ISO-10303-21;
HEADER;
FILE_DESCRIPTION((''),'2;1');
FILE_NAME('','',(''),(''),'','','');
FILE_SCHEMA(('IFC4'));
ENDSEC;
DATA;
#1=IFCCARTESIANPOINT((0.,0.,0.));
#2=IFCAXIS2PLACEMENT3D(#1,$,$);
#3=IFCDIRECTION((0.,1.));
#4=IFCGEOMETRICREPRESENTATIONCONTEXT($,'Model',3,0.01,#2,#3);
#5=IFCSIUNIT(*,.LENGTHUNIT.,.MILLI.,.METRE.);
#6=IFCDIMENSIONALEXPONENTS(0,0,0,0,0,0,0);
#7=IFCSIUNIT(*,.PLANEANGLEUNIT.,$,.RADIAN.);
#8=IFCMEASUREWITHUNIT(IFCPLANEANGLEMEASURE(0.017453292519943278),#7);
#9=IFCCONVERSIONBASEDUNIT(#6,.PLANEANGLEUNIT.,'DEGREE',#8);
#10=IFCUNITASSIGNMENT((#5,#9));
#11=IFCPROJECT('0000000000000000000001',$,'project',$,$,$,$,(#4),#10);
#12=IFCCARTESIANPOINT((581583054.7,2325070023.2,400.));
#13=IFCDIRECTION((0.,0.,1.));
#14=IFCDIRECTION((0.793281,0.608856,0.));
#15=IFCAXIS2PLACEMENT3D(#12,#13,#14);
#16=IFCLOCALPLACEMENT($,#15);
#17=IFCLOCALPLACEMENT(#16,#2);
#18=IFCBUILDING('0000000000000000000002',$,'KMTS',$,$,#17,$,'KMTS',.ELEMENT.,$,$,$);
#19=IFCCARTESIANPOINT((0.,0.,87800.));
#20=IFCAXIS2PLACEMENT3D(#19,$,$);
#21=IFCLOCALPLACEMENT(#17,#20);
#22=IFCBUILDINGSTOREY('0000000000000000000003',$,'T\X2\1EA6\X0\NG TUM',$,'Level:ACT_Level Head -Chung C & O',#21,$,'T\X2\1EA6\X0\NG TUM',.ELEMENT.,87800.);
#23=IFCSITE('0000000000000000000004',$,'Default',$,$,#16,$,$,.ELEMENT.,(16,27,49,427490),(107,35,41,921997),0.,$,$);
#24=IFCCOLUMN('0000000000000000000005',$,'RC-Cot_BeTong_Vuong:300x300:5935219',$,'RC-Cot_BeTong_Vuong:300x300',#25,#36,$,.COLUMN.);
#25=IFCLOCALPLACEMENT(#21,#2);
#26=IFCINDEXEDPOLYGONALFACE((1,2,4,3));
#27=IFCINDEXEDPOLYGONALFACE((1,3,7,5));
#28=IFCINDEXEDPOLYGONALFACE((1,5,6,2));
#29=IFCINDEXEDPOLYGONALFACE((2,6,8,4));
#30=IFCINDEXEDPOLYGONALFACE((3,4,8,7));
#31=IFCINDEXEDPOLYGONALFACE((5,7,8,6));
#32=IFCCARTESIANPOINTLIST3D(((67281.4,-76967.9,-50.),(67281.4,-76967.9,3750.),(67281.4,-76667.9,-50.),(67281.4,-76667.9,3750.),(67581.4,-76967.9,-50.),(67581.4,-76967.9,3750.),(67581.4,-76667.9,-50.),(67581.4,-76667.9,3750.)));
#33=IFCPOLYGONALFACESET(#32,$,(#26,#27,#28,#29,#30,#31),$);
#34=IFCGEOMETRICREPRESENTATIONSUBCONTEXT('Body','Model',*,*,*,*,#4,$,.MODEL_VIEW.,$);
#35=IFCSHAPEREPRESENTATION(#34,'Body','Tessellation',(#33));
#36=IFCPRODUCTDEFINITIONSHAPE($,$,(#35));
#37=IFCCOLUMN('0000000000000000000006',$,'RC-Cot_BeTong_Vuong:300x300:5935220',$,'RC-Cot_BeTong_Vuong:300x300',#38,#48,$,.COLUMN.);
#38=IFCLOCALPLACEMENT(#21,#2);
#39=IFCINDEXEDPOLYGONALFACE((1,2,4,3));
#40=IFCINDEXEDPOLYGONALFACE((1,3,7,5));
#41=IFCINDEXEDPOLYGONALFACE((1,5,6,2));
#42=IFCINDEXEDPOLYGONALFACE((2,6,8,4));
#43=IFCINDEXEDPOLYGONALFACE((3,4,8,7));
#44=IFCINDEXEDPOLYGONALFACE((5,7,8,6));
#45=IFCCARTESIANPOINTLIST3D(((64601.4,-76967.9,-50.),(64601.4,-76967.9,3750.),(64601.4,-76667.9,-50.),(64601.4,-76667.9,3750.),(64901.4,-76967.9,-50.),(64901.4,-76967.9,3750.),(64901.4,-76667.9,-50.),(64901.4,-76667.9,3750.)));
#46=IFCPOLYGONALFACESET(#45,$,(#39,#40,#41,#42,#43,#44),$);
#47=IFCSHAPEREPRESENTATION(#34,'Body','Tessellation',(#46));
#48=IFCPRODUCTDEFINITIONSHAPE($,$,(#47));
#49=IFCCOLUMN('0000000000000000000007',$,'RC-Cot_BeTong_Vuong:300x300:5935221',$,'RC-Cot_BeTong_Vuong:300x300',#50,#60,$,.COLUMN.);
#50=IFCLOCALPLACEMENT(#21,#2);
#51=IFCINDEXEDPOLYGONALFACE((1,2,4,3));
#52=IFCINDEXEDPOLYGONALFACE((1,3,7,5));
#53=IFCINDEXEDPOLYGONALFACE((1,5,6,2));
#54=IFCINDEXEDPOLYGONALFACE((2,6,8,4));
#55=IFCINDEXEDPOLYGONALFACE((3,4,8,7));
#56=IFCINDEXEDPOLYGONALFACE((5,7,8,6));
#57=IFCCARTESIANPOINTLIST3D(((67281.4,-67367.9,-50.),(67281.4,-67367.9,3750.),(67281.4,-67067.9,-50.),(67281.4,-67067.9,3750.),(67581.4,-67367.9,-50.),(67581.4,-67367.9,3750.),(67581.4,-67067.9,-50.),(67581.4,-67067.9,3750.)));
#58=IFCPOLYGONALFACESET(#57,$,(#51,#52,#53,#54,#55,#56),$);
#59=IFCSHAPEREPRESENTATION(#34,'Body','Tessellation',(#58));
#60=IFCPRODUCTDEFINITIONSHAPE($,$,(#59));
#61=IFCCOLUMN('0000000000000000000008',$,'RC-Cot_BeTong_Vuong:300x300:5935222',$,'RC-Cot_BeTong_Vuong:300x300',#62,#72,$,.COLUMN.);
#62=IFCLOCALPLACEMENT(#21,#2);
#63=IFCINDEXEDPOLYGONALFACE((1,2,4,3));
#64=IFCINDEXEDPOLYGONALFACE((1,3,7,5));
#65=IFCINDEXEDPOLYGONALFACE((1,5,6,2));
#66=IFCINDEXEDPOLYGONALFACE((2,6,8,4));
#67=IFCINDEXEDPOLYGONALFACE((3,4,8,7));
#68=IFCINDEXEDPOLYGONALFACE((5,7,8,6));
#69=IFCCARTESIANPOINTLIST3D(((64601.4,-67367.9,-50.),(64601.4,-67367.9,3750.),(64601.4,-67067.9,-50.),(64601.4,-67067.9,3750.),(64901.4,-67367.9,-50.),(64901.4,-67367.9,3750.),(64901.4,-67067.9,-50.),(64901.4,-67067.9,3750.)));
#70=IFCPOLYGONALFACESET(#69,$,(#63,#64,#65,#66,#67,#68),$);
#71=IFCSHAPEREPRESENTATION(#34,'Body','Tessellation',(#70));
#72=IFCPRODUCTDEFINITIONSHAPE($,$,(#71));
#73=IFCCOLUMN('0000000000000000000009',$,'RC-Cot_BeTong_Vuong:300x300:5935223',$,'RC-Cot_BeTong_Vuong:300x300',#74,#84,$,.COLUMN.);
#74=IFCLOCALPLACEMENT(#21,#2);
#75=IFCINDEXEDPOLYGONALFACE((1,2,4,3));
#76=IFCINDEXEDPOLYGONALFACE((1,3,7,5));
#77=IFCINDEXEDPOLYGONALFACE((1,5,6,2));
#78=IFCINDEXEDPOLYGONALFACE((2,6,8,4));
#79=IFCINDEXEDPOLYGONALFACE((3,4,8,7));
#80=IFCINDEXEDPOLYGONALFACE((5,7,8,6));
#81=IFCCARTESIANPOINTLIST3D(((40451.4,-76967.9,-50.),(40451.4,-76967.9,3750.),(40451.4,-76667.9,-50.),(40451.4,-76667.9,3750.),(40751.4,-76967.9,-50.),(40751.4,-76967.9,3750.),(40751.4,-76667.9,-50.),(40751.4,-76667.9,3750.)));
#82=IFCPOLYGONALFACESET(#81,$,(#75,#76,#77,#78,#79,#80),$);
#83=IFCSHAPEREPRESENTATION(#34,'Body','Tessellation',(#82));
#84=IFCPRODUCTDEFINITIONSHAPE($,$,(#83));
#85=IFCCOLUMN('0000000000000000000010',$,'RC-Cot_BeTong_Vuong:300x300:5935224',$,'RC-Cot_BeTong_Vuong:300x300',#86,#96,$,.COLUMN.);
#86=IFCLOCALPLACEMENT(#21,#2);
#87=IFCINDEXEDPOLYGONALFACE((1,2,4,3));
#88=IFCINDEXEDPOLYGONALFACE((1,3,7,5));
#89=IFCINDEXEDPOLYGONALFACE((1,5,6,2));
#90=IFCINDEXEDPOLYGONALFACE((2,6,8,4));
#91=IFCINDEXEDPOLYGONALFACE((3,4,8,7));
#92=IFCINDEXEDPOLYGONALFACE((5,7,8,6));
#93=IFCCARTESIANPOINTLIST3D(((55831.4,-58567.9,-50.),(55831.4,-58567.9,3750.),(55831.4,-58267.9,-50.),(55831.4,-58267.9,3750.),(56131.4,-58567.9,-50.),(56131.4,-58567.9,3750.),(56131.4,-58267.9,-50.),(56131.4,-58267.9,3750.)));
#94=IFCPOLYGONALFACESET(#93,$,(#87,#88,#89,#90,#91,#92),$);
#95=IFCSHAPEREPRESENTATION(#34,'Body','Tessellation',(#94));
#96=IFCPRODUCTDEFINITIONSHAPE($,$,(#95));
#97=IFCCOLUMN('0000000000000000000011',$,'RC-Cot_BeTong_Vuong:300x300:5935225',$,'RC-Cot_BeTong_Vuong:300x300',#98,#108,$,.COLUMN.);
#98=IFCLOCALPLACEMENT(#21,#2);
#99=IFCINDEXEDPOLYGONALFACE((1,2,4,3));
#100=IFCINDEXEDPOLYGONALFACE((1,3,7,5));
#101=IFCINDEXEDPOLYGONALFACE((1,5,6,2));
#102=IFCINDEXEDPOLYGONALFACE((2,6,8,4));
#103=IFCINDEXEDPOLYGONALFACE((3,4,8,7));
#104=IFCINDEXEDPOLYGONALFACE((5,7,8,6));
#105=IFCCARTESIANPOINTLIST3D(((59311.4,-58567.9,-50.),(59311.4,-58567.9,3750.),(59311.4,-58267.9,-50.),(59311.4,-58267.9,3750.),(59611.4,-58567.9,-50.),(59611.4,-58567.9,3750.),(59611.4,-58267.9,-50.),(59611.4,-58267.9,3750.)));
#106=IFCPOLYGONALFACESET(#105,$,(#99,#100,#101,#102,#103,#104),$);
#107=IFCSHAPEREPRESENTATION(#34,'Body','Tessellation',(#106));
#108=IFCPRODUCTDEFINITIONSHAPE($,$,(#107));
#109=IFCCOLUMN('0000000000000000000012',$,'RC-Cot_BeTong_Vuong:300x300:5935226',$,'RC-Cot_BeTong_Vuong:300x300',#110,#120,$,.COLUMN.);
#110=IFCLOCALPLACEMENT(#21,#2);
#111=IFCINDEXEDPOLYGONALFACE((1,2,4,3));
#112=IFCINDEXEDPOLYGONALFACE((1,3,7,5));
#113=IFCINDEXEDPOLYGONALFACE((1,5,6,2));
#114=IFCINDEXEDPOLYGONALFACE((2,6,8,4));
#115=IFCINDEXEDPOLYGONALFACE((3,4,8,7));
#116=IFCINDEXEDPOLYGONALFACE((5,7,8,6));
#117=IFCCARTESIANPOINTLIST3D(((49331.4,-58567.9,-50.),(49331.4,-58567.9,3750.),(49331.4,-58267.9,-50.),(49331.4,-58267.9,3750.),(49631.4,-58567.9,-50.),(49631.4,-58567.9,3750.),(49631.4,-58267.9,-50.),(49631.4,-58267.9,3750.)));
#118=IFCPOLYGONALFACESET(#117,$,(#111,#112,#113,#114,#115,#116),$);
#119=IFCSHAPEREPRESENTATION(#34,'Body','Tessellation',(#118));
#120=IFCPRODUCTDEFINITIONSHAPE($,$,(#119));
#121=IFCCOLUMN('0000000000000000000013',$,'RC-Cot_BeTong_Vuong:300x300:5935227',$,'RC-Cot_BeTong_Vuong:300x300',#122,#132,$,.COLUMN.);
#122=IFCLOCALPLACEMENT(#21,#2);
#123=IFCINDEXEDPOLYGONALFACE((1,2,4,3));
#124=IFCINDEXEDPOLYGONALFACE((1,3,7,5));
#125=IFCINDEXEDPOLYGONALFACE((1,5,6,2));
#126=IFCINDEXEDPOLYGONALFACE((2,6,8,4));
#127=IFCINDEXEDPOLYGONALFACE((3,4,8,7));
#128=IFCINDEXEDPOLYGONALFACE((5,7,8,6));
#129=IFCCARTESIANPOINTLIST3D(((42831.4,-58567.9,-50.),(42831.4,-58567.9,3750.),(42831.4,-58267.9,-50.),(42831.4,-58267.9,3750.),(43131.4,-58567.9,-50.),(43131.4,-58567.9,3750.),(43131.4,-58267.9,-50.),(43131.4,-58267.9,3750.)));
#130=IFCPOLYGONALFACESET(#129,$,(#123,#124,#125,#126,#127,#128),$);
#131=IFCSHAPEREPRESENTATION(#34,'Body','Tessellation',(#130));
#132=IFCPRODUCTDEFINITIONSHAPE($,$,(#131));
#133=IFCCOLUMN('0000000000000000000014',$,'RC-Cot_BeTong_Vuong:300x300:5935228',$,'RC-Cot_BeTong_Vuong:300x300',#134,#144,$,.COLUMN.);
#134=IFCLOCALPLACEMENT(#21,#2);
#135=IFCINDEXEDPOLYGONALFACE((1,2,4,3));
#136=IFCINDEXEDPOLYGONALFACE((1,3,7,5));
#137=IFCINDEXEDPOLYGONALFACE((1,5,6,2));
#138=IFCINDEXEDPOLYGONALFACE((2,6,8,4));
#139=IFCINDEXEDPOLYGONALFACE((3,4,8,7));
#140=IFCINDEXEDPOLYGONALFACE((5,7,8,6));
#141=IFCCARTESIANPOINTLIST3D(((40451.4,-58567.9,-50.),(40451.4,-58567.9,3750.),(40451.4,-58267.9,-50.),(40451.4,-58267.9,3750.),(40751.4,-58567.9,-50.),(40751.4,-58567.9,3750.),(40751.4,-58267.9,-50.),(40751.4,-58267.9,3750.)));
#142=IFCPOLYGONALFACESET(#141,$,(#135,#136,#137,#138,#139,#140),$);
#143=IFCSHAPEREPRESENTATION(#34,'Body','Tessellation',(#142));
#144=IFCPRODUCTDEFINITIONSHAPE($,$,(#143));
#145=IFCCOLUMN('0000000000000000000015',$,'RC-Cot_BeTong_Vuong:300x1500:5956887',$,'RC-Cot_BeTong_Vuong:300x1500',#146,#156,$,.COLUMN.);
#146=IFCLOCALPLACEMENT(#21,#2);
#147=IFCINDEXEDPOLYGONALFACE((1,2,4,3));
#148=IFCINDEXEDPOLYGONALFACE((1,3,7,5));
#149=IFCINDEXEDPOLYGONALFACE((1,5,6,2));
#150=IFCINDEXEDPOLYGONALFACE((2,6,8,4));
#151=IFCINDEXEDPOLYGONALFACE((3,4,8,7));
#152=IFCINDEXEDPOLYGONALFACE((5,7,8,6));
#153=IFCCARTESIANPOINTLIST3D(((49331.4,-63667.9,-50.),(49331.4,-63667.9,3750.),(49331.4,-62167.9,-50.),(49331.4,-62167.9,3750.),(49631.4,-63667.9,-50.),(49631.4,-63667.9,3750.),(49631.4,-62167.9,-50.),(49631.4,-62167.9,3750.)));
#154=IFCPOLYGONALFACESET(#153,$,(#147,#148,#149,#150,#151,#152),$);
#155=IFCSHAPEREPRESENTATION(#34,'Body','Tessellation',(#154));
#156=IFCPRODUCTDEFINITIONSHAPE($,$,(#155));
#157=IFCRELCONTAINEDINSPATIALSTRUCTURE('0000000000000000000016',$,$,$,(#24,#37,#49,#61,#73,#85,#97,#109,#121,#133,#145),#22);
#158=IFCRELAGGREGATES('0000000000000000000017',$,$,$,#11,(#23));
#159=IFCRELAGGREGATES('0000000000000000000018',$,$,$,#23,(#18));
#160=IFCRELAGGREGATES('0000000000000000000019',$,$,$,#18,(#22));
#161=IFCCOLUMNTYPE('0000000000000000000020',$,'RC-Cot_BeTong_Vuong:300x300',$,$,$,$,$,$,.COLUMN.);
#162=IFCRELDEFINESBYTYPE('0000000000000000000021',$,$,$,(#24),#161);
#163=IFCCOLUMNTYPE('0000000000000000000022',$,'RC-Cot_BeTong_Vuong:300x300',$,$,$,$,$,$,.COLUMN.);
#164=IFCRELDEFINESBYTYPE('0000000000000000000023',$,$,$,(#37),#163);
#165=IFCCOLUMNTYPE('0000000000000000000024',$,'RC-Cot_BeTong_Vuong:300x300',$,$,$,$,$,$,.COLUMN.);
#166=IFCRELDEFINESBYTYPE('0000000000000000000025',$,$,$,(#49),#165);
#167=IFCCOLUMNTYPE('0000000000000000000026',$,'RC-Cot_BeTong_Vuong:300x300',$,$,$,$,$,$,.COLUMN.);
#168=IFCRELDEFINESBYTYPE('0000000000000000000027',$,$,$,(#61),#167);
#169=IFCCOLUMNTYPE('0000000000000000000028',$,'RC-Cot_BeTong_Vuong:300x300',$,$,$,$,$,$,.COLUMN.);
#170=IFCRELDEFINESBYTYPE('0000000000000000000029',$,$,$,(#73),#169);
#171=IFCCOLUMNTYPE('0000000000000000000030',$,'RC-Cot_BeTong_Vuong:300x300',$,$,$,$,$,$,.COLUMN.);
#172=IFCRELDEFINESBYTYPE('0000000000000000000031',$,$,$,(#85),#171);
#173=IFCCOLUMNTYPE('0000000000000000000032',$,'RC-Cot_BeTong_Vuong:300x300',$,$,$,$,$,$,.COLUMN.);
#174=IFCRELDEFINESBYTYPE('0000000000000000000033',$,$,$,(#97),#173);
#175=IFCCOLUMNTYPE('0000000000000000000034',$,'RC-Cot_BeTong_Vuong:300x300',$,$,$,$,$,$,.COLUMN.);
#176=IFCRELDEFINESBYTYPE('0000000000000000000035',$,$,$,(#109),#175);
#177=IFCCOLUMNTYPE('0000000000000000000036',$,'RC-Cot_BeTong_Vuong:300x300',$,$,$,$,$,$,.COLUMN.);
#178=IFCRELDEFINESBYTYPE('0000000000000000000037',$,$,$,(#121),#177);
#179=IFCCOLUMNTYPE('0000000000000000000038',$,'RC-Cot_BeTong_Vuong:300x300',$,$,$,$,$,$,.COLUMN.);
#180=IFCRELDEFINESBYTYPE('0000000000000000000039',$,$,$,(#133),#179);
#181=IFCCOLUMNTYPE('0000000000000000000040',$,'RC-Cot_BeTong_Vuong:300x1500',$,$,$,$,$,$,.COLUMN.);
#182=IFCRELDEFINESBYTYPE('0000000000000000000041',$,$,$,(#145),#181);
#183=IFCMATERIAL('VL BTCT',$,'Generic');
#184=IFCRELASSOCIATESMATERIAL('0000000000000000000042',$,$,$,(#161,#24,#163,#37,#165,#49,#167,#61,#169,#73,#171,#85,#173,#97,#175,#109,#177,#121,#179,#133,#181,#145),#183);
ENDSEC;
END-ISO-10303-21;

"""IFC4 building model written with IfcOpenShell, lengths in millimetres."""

from ifc_helpers import new_model, entity, si_unit, converted_unit, direction, frame, origin, place, context, subcontext, project, spatial, indexed_curve, outline, extrude, source, transform, mapped, material, type_object, type_shapes, element, save


model = new_model("IFC4")

# Units and contexts
model_context = context("Model", 3, precision=0.01, world=origin(), true_north=direction((0.0, 1.0)))
body_context = subcontext(model_context, "Body", "Model", "MODEL_VIEW")
ifc_project = project(units=[si_unit("LENGTHUNIT", "METRE", prefix="MILLI"), converted_unit("PLANEANGLEUNIT", "DEGREE", entity("IfcPlaneAngleMeasure", 0.017453292519943278), si_unit("PLANEANGLEUNIT", "RADIAN"), dimensions=[0, 0, 0, 0, 0, 0, 0])], contexts=[model_context])

# Site, building, storey
site_placement = place(None, frame((581583054.7, 2325070023.2, 400.0), z_axis=(0.0, 0.0, 1.0), x_axis=(0.793281, 0.608856, 0.0)))
site = spatial("IfcSite", under=ifc_project, at=site_placement, Name="Default", CompositionType="ELEMENT", RefLatitude=(16, 27, 49, 427490), RefLongitude=(107, 35, 41, 921997), RefElevation=0.0)
building_placement = place(site_placement, origin())
building = spatial("IfcBuilding", under=site, at=building_placement, Name="KMTS", LongName="KMTS", CompositionType="ELEMENT")
storey_placement = place(building_placement, frame((0.0, 0.0, 87800.0)))
storey = spatial("IfcBuildingStorey", under=building, at=storey_placement, Name="TẦNG TUM", ObjectType="Level:ACT_Level Head -Chung C & O", LongName="TẦNG TUM", CompositionType="ELEMENT", Elevation=87800.0)

# Columns
ifc_material = material(Name="VL BTCT", Category="Generic")
column_type_1 = type_object("IfcColumnType", Name="RC-Cot_BeTong_Vuong:300x300", PredefinedType="COLUMN", material=ifc_material)
shared_shape_1 = source(origin(), body_context, "Body", "SweptSolid", [
    extrude(outline(indexed_curve([(-150.0, -150.0), (150.0, -150.0), (150.0, 150.0), (-150.0, 150.0), (-150.0, -150.0)], self_intersect=False)), frame((67431.4, -76817.9, 87750.0), z_axis=(0.0, 0.0, 1.0), x_axis=(-1.0, 0.0, 0.0)), (0.0, 0.0, 1.0), 3800.0),
])
type_shapes(column_type_1, [shared_shape_1])
column_1_placement = place(storey_placement, frame((0.0, 0.0, -87800.0)))
element("IfcColumn", 1, at=column_1_placement, inside=storey, type_object=column_type_1, material=ifc_material, Name="RC-Cot_BeTong_Vuong:300x300:5935219", ObjectType="RC-Cot_BeTong_Vuong:300x300", PredefinedType="COLUMN", context=body_context, shape_type="MappedRepresentation", body=[
    mapped(shared_shape_1, transform((0.0, 0.0, 0.0), scale=1.0)),
])
column_type_2 = type_object("IfcColumnType", Name="RC-Cot_BeTong_Vuong:300x300", PredefinedType="COLUMN", material=ifc_material)
shared_shape_2 = source(origin(), body_context, "Body", "SweptSolid", [
    extrude(outline(indexed_curve([(-150.0, -150.0), (150.0, -150.0), (150.0, 150.0), (-150.0, 150.0), (-150.0, -150.0)], self_intersect=False)), frame((64751.4, -76817.9, 87750.0), z_axis=(0.0, 0.0, 1.0), x_axis=(-1.0, 0.0, 0.0)), (0.0, 0.0, 1.0), 3800.0),
])
type_shapes(column_type_2, [shared_shape_2])
column_2_placement = place(storey_placement, frame((0.0, 0.0, -87800.0)))
element("IfcColumn", 2, at=column_2_placement, inside=storey, type_object=column_type_2, material=ifc_material, Name="RC-Cot_BeTong_Vuong:300x300:5935220", ObjectType="RC-Cot_BeTong_Vuong:300x300", PredefinedType="COLUMN", context=body_context, shape_type="MappedRepresentation", body=[
    mapped(shared_shape_2, transform((0.0, 0.0, 0.0), scale=1.0)),
])
column_type_3 = type_object("IfcColumnType", Name="RC-Cot_BeTong_Vuong:300x300", PredefinedType="COLUMN", material=ifc_material)
shared_shape_3 = source(origin(), body_context, "Body", "SweptSolid", [
    extrude(outline(indexed_curve([(-150.0, -150.0), (150.0, -150.0), (150.0, 150.0), (-150.0, 150.0), (-150.0, -150.0)], self_intersect=False)), frame((67431.4, -67217.9, 87750.0), z_axis=(0.0, 0.0, 1.0), x_axis=(-1.0, 0.0, 0.0)), (0.0, 0.0, 1.0), 3800.0),
])
type_shapes(column_type_3, [shared_shape_3])
column_3_placement = place(storey_placement, frame((0.0, 0.0, -87800.0)))
element("IfcColumn", 3, at=column_3_placement, inside=storey, type_object=column_type_3, material=ifc_material, Name="RC-Cot_BeTong_Vuong:300x300:5935221", ObjectType="RC-Cot_BeTong_Vuong:300x300", PredefinedType="COLUMN", context=body_context, shape_type="MappedRepresentation", body=[
    mapped(shared_shape_3, transform((0.0, 0.0, 0.0), scale=1.0)),
])
column_type_4 = type_object("IfcColumnType", Name="RC-Cot_BeTong_Vuong:300x300", PredefinedType="COLUMN", material=ifc_material)
shared_shape_4 = source(origin(), body_context, "Body", "SweptSolid", [
    extrude(outline(indexed_curve([(-150.0, -150.0), (150.0, -150.0), (150.0, 150.0), (-150.0, 150.0), (-150.0, -150.0)], self_intersect=False)), frame((64751.4, -67217.9, 87750.0), z_axis=(0.0, 0.0, 1.0), x_axis=(-1.0, 0.0, 0.0)), (0.0, 0.0, 1.0), 3800.0),
])
type_shapes(column_type_4, [shared_shape_4])
column_4_placement = place(storey_placement, frame((0.0, 0.0, -87800.0)))
element("IfcColumn", 4, at=column_4_placement, inside=storey, type_object=column_type_4, material=ifc_material, Name="RC-Cot_BeTong_Vuong:300x300:5935222", ObjectType="RC-Cot_BeTong_Vuong:300x300", PredefinedType="COLUMN", context=body_context, shape_type="MappedRepresentation", body=[
    mapped(shared_shape_4, transform((0.0, 0.0, 0.0), scale=1.0)),
])
column_type_5 = type_object("IfcColumnType", Name="RC-Cot_BeTong_Vuong:300x300", PredefinedType="COLUMN", material=ifc_material)
shared_shape_5 = source(origin(), body_context, "Body", "SweptSolid", [
    extrude(outline(indexed_curve([(-150.0, -150.0), (150.0, -150.0), (150.0, 150.0), (-150.0, 150.0), (-150.0, -150.0)], self_intersect=False)), frame((40601.4, -76817.9, 87750.0), z_axis=(0.0, 0.0, 1.0), x_axis=(-1.0, 0.0, 0.0)), (0.0, 0.0, 1.0), 3800.0),
])
type_shapes(column_type_5, [shared_shape_5])
column_5_placement = place(storey_placement, frame((0.0, 0.0, -87800.0)))
element("IfcColumn", 5, at=column_5_placement, inside=storey, type_object=column_type_5, material=ifc_material, Name="RC-Cot_BeTong_Vuong:300x300:5935223", ObjectType="RC-Cot_BeTong_Vuong:300x300", PredefinedType="COLUMN", context=body_context, shape_type="MappedRepresentation", body=[
    mapped(shared_shape_5, transform((0.0, 0.0, 0.0), scale=1.0)),
])
column_type_6 = type_object("IfcColumnType", Name="RC-Cot_BeTong_Vuong:300x300", PredefinedType="COLUMN", material=ifc_material)
shared_shape_6 = source(origin(), body_context, "Body", "SweptSolid", [
    extrude(outline(indexed_curve([(-150.0, -150.0), (150.0, -150.0), (150.0, 150.0), (-150.0, 150.0), (-150.0, -150.0)], self_intersect=False)), frame((55981.4, -58417.9, 87750.0), z_axis=(0.0, 0.0, 1.0), x_axis=(-1.0, 0.0, 0.0)), (0.0, 0.0, 1.0), 3800.0),
])
type_shapes(column_type_6, [shared_shape_6])
column_6_placement = place(storey_placement, frame((0.0, 0.0, -87800.0)))
element("IfcColumn", 6, at=column_6_placement, inside=storey, type_object=column_type_6, material=ifc_material, Name="RC-Cot_BeTong_Vuong:300x300:5935224", ObjectType="RC-Cot_BeTong_Vuong:300x300", PredefinedType="COLUMN", context=body_context, shape_type="MappedRepresentation", body=[
    mapped(shared_shape_6, transform((0.0, 0.0, 0.0), scale=1.0)),
])
column_type_7 = type_object("IfcColumnType", Name="RC-Cot_BeTong_Vuong:300x300", PredefinedType="COLUMN", material=ifc_material)
shared_shape_7 = source(origin(), body_context, "Body", "SweptSolid", [
    extrude(outline(indexed_curve([(-150.0, -150.0), (150.0, -150.0), (150.0, 150.0), (-150.0, 150.0), (-150.0, -150.0)], self_intersect=False)), frame((59461.4, -58417.9, 87750.0), z_axis=(0.0, 0.0, 1.0), x_axis=(-1.0, 0.0, 0.0)), (0.0, 0.0, 1.0), 3800.0),
])
type_shapes(column_type_7, [shared_shape_7])
column_7_placement = place(storey_placement, frame((0.0, 0.0, -87800.0)))
element("IfcColumn", 7, at=column_7_placement, inside=storey, type_object=column_type_7, material=ifc_material, Name="RC-Cot_BeTong_Vuong:300x300:5935225", ObjectType="RC-Cot_BeTong_Vuong:300x300", PredefinedType="COLUMN", context=body_context, shape_type="MappedRepresentation", body=[
    mapped(shared_shape_7, transform((0.0, 0.0, 0.0), scale=1.0)),
])
column_type_8 = type_object("IfcColumnType", Name="RC-Cot_BeTong_Vuong:300x300", PredefinedType="COLUMN", material=ifc_material)
shared_shape_8 = source(origin(), body_context, "Body", "SweptSolid", [
    extrude(outline(indexed_curve([(-150.0, -150.0), (150.0, -150.0), (150.0, 150.0), (-150.0, 150.0), (-150.0, -150.0)], self_intersect=False)), frame((49481.4, -58417.9, 87750.0), z_axis=(0.0, 0.0, 1.0), x_axis=(-1.0, 0.0, 0.0)), (0.0, 0.0, 1.0), 3800.0),
])
type_shapes(column_type_8, [shared_shape_8])
column_8_placement = place(storey_placement, frame((0.0, 0.0, -87800.0)))
element("IfcColumn", 8, at=column_8_placement, inside=storey, type_object=column_type_8, material=ifc_material, Name="RC-Cot_BeTong_Vuong:300x300:5935226", ObjectType="RC-Cot_BeTong_Vuong:300x300", PredefinedType="COLUMN", context=body_context, shape_type="MappedRepresentation", body=[
    mapped(shared_shape_8, transform((0.0, 0.0, 0.0), scale=1.0)),
])
column_type_9 = type_object("IfcColumnType", Name="RC-Cot_BeTong_Vuong:300x300", PredefinedType="COLUMN", material=ifc_material)
shared_shape_9 = source(origin(), body_context, "Body", "SweptSolid", [
    extrude(outline(indexed_curve([(-150.0, -150.0), (150.0, -150.0), (150.0, 150.0), (-150.0, 150.0), (-150.0, -150.0)], self_intersect=False)), frame((42981.4, -58417.9, 87750.0), z_axis=(0.0, 0.0, 1.0), x_axis=(-1.0, 0.0, 0.0)), (0.0, 0.0, 1.0), 3800.0),
])
type_shapes(column_type_9, [shared_shape_9])
column_9_placement = place(storey_placement, frame((0.0, 0.0, -87800.0)))
element("IfcColumn", 9, at=column_9_placement, inside=storey, type_object=column_type_9, material=ifc_material, Name="RC-Cot_BeTong_Vuong:300x300:5935227", ObjectType="RC-Cot_BeTong_Vuong:300x300", PredefinedType="COLUMN", context=body_context, shape_type="MappedRepresentation", body=[
    mapped(shared_shape_9, transform((0.0, 0.0, 0.0), scale=1.0)),
])
column_type_10 = type_object("IfcColumnType", Name="RC-Cot_BeTong_Vuong:300x300", PredefinedType="COLUMN", material=ifc_material)
shared_shape_10 = source(origin(), body_context, "Body", "SweptSolid", [
    extrude(outline(indexed_curve([(-150.0, -150.0), (150.0, -150.0), (150.0, 150.0), (-150.0, 150.0), (-150.0, -150.0)], self_intersect=False)), frame((40601.4, -58417.9, 87750.0), z_axis=(0.0, 0.0, 1.0), x_axis=(-1.0, 0.0, 0.0)), (0.0, 0.0, 1.0), 3800.0),
])
type_shapes(column_type_10, [shared_shape_10])
column_10_placement = place(storey_placement, frame((0.0, 0.0, -87800.0)))
element("IfcColumn", 10, at=column_10_placement, inside=storey, type_object=column_type_10, material=ifc_material, Name="RC-Cot_BeTong_Vuong:300x300:5935228", ObjectType="RC-Cot_BeTong_Vuong:300x300", PredefinedType="COLUMN", context=body_context, shape_type="MappedRepresentation", body=[
    mapped(shared_shape_10, transform((0.0, 0.0, 0.0), scale=1.0)),
])
column_type_11 = type_object("IfcColumnType", Name="RC-Cot_BeTong_Vuong:300x1500", PredefinedType="COLUMN", material=ifc_material)
shared_shape_11 = source(origin(), body_context, "Body", "SweptSolid", [
    extrude(outline(indexed_curve([(-1900.0, -750.0), (1900.0, -750.0), (1900.0, 750.0), (-1900.0, 750.0), (-1900.0, -750.0)], self_intersect=False)), frame((49331.4, -62917.9, 89650.0), z_axis=(1.0, 0.0, 0.0), x_axis=(0.0, 0.0, 1.0)), (0.0, 0.0, 1.0), 300.0),
])
type_shapes(column_type_11, [shared_shape_11])
column_11_placement = place(storey_placement, frame((0.0, 0.0, -87800.0)))
element("IfcColumn", 11, at=column_11_placement, inside=storey, type_object=column_type_11, material=ifc_material, Name="RC-Cot_BeTong_Vuong:300x1500:5956887", ObjectType="RC-Cot_BeTong_Vuong:300x1500", PredefinedType="COLUMN", context=body_context, shape_type="MappedRepresentation", body=[
    mapped(shared_shape_11, transform((0.0, 0.0, 0.0), scale=1.0)),
])

save(model, "model.ifc")
